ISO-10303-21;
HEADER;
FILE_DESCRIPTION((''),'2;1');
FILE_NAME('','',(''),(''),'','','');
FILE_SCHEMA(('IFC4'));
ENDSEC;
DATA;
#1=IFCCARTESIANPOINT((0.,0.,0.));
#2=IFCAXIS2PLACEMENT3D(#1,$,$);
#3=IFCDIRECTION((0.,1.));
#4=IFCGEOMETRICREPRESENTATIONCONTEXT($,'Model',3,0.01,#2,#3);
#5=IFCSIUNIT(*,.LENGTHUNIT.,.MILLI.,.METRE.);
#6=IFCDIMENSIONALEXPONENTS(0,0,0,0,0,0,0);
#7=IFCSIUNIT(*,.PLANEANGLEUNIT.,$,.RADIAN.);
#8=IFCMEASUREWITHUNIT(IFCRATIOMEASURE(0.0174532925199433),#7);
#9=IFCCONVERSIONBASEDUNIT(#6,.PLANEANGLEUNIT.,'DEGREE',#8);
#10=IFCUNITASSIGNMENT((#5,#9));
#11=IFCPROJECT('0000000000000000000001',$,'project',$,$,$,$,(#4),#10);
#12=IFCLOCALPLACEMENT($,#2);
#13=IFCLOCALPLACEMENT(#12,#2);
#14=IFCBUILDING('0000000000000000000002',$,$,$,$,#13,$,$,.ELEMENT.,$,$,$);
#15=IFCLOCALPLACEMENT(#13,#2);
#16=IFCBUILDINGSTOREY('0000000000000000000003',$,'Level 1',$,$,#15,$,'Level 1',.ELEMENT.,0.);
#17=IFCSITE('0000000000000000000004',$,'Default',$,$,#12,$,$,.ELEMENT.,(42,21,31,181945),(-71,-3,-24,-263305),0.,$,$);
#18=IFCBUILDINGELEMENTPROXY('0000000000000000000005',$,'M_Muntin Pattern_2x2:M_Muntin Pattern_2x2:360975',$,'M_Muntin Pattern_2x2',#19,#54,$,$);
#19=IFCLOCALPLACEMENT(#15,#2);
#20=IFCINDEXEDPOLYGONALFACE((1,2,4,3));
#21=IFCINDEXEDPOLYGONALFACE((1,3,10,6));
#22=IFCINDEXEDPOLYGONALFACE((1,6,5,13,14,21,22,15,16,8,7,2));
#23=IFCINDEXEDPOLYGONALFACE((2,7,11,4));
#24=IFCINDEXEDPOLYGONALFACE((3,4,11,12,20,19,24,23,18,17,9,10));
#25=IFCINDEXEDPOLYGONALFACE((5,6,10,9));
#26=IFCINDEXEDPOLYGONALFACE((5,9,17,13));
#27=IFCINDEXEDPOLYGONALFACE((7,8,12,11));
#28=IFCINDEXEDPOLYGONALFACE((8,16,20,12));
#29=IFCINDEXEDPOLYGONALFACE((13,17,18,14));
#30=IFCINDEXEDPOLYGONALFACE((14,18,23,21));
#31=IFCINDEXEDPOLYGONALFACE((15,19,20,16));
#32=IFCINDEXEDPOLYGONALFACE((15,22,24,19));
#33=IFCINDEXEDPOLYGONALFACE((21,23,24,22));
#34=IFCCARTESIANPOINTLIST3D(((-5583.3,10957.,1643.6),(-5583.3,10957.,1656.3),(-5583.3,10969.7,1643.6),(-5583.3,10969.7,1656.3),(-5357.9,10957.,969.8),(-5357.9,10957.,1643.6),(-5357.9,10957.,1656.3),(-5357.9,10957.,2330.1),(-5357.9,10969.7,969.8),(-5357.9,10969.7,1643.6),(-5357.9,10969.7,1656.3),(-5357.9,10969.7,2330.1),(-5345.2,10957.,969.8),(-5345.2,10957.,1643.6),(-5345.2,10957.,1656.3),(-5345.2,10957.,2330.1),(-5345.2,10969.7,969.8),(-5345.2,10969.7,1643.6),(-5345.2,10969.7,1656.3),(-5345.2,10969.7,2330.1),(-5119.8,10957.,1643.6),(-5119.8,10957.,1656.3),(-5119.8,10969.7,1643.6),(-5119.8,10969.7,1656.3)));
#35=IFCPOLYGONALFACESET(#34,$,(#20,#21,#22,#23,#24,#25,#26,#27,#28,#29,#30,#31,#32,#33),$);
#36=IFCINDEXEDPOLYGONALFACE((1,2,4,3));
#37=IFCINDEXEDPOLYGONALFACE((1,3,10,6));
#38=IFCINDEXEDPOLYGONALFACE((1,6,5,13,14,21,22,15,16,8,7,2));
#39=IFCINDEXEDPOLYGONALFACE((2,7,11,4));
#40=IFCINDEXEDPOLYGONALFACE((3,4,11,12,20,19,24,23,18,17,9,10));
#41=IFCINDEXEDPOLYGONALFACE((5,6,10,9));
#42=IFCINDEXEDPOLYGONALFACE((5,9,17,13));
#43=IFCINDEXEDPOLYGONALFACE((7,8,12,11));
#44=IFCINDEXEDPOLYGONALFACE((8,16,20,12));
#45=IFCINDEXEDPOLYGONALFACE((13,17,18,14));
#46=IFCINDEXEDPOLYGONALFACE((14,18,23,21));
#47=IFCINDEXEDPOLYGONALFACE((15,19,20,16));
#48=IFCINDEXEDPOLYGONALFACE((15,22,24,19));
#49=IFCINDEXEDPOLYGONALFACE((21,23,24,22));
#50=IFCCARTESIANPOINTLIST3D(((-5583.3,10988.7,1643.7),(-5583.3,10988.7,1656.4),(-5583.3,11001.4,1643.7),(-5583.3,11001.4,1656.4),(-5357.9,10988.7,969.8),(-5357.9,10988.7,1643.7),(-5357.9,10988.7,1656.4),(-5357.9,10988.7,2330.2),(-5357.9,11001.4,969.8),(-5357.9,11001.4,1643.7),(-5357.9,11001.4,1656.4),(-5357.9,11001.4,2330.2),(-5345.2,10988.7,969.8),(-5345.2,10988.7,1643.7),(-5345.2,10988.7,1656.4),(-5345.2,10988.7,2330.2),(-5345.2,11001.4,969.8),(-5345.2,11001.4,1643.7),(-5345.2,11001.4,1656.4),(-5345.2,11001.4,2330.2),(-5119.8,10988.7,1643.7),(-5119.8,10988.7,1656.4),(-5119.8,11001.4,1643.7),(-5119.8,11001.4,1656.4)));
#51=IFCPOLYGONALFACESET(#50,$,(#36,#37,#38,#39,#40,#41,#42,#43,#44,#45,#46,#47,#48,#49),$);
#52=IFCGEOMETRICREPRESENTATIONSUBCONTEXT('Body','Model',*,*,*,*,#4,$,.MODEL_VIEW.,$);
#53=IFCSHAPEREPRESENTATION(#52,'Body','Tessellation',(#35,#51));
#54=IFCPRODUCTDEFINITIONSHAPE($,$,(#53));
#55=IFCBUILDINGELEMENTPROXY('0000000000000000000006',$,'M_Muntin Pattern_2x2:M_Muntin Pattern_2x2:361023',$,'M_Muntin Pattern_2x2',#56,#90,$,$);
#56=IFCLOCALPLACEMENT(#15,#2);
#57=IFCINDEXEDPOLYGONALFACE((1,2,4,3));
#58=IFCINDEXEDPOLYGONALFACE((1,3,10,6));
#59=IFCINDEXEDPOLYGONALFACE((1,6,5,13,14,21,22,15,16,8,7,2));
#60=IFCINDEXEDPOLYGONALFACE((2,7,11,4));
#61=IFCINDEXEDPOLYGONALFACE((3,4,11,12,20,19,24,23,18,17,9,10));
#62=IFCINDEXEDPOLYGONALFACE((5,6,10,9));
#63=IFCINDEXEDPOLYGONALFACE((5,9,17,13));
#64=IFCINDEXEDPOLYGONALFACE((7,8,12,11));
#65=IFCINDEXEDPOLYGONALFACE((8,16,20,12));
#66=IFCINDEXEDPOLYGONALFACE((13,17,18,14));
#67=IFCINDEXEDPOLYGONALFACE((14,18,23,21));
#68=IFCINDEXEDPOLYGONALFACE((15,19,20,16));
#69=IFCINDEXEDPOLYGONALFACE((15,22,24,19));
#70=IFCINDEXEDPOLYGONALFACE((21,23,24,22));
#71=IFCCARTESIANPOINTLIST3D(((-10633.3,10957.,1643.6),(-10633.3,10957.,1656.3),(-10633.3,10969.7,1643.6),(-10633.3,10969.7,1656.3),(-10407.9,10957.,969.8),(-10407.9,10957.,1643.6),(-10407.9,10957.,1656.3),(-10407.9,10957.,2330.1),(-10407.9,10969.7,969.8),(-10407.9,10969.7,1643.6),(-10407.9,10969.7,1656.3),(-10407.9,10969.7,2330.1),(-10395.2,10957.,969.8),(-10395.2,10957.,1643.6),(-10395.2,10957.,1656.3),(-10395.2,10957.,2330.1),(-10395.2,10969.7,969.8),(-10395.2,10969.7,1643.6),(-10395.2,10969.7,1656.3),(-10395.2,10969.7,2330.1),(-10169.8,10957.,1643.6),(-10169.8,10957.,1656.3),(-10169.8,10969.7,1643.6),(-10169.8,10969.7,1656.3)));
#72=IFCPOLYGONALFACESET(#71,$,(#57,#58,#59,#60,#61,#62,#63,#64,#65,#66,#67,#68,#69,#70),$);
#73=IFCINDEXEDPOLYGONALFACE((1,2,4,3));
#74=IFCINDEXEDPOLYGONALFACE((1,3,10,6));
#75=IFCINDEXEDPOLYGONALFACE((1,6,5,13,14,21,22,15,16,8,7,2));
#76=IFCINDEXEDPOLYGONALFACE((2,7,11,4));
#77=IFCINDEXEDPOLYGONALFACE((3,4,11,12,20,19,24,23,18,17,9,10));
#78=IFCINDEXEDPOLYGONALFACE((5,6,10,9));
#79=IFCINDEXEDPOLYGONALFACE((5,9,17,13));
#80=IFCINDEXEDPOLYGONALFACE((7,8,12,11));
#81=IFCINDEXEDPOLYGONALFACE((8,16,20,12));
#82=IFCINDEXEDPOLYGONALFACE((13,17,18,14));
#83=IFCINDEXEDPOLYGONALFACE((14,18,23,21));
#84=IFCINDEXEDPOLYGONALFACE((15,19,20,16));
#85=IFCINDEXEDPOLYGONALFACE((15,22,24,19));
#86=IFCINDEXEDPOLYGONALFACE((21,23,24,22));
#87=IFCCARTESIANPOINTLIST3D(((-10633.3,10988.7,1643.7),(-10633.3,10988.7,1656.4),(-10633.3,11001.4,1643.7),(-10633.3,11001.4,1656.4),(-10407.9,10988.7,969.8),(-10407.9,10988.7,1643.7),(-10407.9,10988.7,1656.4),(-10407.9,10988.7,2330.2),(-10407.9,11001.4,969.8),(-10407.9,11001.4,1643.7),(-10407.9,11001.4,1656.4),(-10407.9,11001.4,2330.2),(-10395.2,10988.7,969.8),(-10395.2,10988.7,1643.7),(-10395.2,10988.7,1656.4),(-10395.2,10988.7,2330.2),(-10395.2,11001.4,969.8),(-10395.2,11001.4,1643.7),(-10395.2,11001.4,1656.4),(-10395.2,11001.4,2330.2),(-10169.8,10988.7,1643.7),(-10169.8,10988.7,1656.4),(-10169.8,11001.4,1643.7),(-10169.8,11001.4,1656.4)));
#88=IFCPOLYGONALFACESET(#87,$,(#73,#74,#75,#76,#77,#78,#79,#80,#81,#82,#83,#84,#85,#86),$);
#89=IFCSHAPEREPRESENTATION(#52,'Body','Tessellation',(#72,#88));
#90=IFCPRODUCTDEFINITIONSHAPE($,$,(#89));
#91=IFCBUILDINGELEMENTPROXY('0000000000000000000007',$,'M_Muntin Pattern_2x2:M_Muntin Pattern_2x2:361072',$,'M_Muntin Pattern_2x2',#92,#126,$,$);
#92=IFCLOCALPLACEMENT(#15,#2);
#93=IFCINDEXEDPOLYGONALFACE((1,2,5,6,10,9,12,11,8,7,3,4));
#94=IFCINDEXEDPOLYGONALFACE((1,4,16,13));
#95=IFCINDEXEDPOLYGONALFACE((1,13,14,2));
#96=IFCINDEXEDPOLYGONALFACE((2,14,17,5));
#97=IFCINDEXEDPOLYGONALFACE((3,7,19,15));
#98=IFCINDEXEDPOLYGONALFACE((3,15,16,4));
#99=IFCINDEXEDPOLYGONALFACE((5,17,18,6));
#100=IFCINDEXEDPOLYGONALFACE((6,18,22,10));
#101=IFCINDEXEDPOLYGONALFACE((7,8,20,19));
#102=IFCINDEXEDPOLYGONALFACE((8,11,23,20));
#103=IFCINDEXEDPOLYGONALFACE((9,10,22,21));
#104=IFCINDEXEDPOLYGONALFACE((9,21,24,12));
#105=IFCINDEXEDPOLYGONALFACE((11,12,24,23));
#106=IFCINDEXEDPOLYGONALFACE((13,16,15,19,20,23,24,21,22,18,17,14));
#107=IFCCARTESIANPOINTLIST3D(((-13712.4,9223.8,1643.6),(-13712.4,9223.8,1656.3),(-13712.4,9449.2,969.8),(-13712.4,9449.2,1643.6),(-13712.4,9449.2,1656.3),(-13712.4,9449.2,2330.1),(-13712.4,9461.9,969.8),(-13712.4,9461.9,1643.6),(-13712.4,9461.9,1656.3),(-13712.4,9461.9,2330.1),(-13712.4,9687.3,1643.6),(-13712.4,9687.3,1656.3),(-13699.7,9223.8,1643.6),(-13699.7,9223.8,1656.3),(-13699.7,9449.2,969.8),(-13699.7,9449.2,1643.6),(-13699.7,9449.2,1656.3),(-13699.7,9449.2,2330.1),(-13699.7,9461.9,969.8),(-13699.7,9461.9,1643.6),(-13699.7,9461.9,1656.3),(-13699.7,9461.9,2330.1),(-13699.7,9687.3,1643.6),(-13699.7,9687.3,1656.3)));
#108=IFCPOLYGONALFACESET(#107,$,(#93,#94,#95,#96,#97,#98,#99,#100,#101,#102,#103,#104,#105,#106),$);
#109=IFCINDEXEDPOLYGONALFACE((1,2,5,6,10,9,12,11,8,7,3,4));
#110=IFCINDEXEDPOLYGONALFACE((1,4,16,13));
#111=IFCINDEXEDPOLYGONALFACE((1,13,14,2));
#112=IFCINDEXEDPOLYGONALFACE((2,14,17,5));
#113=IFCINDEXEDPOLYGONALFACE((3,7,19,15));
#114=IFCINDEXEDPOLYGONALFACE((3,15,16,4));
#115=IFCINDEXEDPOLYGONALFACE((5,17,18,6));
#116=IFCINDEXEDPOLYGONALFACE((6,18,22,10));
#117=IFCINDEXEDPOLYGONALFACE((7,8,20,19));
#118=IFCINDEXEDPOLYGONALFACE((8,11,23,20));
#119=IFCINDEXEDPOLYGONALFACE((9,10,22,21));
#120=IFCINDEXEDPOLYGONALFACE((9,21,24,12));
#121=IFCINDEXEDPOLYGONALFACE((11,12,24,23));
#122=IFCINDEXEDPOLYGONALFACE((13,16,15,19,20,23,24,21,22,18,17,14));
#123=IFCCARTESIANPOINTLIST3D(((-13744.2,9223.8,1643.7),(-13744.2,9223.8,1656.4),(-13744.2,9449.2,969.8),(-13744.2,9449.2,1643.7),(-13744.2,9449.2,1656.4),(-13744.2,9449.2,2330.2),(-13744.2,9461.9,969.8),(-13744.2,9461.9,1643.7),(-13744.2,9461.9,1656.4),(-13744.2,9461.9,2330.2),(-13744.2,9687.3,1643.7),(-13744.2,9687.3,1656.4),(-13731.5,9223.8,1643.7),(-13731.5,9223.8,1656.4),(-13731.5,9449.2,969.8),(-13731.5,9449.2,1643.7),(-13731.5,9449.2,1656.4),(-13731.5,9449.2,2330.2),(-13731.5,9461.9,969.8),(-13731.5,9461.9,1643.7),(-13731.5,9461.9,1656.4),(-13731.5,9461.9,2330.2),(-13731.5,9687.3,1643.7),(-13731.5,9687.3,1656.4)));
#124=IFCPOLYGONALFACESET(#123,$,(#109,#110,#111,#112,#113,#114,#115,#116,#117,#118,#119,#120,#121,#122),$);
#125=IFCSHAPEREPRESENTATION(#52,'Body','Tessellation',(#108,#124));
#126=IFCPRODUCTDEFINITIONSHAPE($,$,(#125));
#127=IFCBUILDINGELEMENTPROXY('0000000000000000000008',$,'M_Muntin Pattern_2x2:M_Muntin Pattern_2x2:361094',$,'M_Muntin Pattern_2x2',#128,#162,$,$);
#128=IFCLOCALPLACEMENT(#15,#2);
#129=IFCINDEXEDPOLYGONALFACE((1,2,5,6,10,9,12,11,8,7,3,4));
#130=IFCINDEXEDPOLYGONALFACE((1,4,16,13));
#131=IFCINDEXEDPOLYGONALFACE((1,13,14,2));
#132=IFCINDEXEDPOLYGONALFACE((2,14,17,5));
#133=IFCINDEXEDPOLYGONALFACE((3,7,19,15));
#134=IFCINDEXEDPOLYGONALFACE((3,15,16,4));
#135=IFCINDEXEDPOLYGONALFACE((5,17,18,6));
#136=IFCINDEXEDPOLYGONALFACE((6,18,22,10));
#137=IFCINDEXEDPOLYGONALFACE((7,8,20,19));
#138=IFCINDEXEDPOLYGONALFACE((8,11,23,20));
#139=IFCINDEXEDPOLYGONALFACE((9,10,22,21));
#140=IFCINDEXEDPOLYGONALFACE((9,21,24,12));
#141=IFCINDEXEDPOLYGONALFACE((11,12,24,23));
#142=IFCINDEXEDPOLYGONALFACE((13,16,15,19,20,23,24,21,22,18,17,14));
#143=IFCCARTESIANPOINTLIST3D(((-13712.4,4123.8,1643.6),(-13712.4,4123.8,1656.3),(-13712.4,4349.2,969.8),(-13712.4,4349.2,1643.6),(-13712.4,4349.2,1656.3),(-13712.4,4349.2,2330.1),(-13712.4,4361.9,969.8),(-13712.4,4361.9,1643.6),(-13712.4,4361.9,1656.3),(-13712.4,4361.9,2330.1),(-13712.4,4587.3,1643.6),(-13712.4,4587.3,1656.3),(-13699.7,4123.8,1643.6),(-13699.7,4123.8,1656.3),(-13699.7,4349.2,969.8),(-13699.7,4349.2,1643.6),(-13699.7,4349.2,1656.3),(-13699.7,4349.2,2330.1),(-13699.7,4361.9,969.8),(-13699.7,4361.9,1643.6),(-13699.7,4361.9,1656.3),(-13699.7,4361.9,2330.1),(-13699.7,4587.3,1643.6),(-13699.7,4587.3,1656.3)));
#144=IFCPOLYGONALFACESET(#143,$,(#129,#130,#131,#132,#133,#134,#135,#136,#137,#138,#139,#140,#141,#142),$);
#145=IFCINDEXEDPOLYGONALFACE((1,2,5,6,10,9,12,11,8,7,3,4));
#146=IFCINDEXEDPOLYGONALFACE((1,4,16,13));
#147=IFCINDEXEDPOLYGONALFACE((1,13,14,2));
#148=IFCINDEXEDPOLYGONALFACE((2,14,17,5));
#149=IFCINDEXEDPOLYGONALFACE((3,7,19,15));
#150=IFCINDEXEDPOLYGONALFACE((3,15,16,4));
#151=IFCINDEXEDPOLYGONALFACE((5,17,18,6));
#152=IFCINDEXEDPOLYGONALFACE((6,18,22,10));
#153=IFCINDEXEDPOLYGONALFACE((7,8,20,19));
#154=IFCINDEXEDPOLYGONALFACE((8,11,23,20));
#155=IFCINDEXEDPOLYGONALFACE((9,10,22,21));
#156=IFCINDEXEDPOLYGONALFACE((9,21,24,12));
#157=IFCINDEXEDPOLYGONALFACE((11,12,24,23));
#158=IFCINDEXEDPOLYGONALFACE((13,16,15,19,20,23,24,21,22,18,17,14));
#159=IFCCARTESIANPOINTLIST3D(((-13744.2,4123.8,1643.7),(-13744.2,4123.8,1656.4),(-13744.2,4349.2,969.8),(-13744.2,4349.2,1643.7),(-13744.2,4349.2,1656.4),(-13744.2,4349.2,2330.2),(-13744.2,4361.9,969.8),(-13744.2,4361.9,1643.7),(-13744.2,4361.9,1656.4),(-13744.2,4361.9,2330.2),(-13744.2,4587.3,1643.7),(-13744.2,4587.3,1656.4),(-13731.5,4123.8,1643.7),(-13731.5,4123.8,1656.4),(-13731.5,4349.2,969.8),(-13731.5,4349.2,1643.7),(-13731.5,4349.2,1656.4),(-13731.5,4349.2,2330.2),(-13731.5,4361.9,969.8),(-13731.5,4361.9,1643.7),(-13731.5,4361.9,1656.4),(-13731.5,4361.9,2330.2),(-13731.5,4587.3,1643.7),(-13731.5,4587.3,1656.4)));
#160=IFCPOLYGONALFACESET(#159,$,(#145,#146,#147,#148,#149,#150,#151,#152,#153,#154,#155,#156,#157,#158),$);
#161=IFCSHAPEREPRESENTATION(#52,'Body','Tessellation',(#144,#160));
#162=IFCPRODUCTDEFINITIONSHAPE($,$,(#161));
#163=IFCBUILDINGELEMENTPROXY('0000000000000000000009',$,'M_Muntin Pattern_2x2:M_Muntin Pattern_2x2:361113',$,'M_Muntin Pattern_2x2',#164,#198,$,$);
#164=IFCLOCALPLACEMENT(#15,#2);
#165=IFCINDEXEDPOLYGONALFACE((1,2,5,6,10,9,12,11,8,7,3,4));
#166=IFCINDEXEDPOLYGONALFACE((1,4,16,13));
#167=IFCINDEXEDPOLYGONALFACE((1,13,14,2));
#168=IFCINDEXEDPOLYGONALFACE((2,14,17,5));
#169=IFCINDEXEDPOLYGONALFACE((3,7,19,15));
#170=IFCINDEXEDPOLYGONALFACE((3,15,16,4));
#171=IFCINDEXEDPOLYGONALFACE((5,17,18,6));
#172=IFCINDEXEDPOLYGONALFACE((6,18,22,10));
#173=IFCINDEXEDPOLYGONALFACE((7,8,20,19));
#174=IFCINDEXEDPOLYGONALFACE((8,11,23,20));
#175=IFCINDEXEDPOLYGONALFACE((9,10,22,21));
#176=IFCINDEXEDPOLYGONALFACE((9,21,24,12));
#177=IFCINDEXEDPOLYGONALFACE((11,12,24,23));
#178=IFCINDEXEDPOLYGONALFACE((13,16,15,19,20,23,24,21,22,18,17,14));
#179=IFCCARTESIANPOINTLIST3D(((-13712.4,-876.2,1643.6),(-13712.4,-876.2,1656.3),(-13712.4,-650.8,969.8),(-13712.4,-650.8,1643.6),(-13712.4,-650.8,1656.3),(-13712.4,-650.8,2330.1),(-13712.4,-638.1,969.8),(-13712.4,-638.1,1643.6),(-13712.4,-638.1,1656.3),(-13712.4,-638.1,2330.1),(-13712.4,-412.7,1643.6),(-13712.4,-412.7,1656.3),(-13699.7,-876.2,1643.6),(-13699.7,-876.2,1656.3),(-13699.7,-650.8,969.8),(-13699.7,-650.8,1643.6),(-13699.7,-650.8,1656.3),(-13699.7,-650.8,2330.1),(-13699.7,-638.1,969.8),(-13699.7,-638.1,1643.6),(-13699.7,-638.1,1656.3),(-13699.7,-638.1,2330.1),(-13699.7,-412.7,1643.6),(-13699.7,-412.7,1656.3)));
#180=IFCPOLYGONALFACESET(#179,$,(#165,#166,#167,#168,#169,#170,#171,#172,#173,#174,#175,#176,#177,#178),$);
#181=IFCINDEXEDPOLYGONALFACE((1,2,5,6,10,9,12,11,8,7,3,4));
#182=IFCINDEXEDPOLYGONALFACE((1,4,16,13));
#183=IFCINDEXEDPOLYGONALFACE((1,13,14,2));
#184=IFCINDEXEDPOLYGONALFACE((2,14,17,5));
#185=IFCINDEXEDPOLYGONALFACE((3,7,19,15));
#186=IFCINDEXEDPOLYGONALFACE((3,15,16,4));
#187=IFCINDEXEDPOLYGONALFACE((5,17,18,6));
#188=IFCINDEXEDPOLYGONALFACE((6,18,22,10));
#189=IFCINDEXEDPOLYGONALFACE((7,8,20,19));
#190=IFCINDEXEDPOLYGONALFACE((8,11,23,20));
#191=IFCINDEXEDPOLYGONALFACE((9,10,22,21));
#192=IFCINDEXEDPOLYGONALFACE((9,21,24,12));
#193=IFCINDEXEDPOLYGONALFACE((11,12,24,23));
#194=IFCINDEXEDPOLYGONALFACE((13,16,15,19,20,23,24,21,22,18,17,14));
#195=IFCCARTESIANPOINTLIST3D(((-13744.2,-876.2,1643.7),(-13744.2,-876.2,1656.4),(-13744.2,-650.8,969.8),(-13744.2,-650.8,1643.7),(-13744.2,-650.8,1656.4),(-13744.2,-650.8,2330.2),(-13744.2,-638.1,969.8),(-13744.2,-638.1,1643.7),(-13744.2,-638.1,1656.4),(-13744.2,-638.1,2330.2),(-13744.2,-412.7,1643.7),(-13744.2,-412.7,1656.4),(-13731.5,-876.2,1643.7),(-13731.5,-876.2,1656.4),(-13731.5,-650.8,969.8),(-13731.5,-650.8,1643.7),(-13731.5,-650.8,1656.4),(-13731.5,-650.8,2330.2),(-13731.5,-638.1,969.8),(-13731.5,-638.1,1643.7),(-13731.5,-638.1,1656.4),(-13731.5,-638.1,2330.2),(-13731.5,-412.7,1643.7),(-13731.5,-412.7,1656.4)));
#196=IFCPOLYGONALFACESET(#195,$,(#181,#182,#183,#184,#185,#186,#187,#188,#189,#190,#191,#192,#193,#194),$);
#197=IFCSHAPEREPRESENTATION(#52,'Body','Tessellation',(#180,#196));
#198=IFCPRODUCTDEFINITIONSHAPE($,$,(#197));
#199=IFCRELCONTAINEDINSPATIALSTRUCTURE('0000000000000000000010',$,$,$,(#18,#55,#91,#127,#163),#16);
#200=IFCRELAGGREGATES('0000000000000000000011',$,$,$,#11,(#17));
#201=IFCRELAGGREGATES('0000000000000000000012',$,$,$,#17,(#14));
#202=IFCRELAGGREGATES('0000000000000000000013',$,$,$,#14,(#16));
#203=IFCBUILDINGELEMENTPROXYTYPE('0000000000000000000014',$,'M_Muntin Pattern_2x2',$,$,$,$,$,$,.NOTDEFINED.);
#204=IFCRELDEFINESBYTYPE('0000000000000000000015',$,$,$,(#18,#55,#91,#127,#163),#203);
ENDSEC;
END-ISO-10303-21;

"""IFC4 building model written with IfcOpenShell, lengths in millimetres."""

from ifc_helpers import new_model, entity, si_unit, converted_unit, direction, frame, origin, place, context, subcontext, project, spatial, polyline, outline, extrude, source, transform, mapped, type_object, type_shapes, element, save


model = new_model("IFC4")

# Units and contexts
model_context = context("Model", 3, precision=0.01, world=origin(), true_north=direction((0.0, 1.0)))
body_context = subcontext(model_context, "Body", "Model", "MODEL_VIEW")
ifc_project = project(units=[si_unit("LENGTHUNIT", "METRE", prefix="MILLI"), converted_unit("PLANEANGLEUNIT", "DEGREE", entity("IfcRatioMeasure", 0.0174532925199433), si_unit("PLANEANGLEUNIT", "RADIAN"), dimensions=[0, 0, 0, 0, 0, 0, 0])], contexts=[model_context])

# Site, building, storey
site_placement = place(None, origin())
site = spatial("IfcSite", under=ifc_project, at=site_placement, Name="Default", CompositionType="ELEMENT", RefLatitude=(42, 21, 31, 181945), RefLongitude=(-71, -3, -24, -263305), RefElevation=0.0)
building_placement = place(site_placement, origin())
building = spatial("IfcBuilding", under=site, at=building_placement, CompositionType="ELEMENT")
storey_placement = place(building_placement, origin())
storey = spatial("IfcBuildingStorey", under=building, at=storey_placement, Name="Level 1", LongName="Level 1", CompositionType="ELEMENT", Elevation=0.0)

# Building element proxies
building_element_proxy_type_1 = type_object("IfcBuildingElementProxyType", Name="M_Muntin Pattern_2x2", PredefinedType="NOTDEFINED")
shared_shape_1 = source(origin(), body_context, "Body", "SweptSolid", [
    extrude(outline(polyline([(6.4, -6.4), (680.1, -6.4), (680.1, 6.3), (6.4, 6.3), (6.4, 231.7), (-6.3, 231.7), (-6.3, 6.3), (-680.2, 6.3), (-680.2, -6.4), (-6.3, -6.4), (-6.3, -231.7), (6.4, -231.7), (6.4, -6.4)])), frame((0.0, 9.5, 680.1), z_axis=(0.0, 1.0, 0.0), x_axis=(0.0, 0.0, 1.0)), (0.0, 0.0, 1.0), 12.7),
    extrude(outline(polyline([(6.4, -6.4), (680.2, -6.4), (680.2, 6.3), (6.4, 6.3), (6.4, 231.7), (-6.3, 231.7), (-6.3, 6.3), (-680.2, 6.3), (-680.2, -6.4), (-6.3, -6.4), (-6.3, -231.7), (6.4, -231.7), (6.4, -6.4)])), frame((0.0, -22.2, 680.2), z_axis=(0.0, 1.0, 0.0), x_axis=(0.0, 0.0, 1.0)), (0.0, 0.0, 1.0), 12.7),
])
type_shapes(building_element_proxy_type_1, [shared_shape_1])
for number, where, z_axis, x_axis, name in (
    (1, (-5351.5, 10979.2, 969.8), (0.0, 0.0, 1.0), (-1.0, 0.0, 0.0), "M_Muntin Pattern_2x2:M_Muntin Pattern_2x2:360975"),
    (2, (-10401.5, 10979.2, 969.8), (0.0, 0.0, 1.0), (-1.0, 0.0, 0.0), "M_Muntin Pattern_2x2:M_Muntin Pattern_2x2:361023"),
    (3, (-13722.0, 9455.6, 969.8), (0.0, 0.0, 1.0), (0.0, -1.0, 0.0), "M_Muntin Pattern_2x2:M_Muntin Pattern_2x2:361072"),
    (4, (-13722.0, 4355.6, 969.8), (0.0, 0.0, 1.0), (0.0, -1.0, 0.0), "M_Muntin Pattern_2x2:M_Muntin Pattern_2x2:361094"),
    (5, (-13722.0, -644.4, 969.8), (0.0, 0.0, 1.0), (0.0, -1.0, 0.0), "M_Muntin Pattern_2x2:M_Muntin Pattern_2x2:361113"),
):
    element("IfcBuildingElementProxy", number, at=place(storey_placement, frame(where, z_axis=z_axis, x_axis=x_axis)), inside=storey, type_object=building_element_proxy_type_1, Name=name, ObjectType="M_Muntin Pattern_2x2", context=body_context, shape_type="MappedRepresentation", body=[
        mapped(shared_shape_1, transform((0.0, 0.0, 0.0), scale=1.0)),
    ])

save(model, "model.ifc")
